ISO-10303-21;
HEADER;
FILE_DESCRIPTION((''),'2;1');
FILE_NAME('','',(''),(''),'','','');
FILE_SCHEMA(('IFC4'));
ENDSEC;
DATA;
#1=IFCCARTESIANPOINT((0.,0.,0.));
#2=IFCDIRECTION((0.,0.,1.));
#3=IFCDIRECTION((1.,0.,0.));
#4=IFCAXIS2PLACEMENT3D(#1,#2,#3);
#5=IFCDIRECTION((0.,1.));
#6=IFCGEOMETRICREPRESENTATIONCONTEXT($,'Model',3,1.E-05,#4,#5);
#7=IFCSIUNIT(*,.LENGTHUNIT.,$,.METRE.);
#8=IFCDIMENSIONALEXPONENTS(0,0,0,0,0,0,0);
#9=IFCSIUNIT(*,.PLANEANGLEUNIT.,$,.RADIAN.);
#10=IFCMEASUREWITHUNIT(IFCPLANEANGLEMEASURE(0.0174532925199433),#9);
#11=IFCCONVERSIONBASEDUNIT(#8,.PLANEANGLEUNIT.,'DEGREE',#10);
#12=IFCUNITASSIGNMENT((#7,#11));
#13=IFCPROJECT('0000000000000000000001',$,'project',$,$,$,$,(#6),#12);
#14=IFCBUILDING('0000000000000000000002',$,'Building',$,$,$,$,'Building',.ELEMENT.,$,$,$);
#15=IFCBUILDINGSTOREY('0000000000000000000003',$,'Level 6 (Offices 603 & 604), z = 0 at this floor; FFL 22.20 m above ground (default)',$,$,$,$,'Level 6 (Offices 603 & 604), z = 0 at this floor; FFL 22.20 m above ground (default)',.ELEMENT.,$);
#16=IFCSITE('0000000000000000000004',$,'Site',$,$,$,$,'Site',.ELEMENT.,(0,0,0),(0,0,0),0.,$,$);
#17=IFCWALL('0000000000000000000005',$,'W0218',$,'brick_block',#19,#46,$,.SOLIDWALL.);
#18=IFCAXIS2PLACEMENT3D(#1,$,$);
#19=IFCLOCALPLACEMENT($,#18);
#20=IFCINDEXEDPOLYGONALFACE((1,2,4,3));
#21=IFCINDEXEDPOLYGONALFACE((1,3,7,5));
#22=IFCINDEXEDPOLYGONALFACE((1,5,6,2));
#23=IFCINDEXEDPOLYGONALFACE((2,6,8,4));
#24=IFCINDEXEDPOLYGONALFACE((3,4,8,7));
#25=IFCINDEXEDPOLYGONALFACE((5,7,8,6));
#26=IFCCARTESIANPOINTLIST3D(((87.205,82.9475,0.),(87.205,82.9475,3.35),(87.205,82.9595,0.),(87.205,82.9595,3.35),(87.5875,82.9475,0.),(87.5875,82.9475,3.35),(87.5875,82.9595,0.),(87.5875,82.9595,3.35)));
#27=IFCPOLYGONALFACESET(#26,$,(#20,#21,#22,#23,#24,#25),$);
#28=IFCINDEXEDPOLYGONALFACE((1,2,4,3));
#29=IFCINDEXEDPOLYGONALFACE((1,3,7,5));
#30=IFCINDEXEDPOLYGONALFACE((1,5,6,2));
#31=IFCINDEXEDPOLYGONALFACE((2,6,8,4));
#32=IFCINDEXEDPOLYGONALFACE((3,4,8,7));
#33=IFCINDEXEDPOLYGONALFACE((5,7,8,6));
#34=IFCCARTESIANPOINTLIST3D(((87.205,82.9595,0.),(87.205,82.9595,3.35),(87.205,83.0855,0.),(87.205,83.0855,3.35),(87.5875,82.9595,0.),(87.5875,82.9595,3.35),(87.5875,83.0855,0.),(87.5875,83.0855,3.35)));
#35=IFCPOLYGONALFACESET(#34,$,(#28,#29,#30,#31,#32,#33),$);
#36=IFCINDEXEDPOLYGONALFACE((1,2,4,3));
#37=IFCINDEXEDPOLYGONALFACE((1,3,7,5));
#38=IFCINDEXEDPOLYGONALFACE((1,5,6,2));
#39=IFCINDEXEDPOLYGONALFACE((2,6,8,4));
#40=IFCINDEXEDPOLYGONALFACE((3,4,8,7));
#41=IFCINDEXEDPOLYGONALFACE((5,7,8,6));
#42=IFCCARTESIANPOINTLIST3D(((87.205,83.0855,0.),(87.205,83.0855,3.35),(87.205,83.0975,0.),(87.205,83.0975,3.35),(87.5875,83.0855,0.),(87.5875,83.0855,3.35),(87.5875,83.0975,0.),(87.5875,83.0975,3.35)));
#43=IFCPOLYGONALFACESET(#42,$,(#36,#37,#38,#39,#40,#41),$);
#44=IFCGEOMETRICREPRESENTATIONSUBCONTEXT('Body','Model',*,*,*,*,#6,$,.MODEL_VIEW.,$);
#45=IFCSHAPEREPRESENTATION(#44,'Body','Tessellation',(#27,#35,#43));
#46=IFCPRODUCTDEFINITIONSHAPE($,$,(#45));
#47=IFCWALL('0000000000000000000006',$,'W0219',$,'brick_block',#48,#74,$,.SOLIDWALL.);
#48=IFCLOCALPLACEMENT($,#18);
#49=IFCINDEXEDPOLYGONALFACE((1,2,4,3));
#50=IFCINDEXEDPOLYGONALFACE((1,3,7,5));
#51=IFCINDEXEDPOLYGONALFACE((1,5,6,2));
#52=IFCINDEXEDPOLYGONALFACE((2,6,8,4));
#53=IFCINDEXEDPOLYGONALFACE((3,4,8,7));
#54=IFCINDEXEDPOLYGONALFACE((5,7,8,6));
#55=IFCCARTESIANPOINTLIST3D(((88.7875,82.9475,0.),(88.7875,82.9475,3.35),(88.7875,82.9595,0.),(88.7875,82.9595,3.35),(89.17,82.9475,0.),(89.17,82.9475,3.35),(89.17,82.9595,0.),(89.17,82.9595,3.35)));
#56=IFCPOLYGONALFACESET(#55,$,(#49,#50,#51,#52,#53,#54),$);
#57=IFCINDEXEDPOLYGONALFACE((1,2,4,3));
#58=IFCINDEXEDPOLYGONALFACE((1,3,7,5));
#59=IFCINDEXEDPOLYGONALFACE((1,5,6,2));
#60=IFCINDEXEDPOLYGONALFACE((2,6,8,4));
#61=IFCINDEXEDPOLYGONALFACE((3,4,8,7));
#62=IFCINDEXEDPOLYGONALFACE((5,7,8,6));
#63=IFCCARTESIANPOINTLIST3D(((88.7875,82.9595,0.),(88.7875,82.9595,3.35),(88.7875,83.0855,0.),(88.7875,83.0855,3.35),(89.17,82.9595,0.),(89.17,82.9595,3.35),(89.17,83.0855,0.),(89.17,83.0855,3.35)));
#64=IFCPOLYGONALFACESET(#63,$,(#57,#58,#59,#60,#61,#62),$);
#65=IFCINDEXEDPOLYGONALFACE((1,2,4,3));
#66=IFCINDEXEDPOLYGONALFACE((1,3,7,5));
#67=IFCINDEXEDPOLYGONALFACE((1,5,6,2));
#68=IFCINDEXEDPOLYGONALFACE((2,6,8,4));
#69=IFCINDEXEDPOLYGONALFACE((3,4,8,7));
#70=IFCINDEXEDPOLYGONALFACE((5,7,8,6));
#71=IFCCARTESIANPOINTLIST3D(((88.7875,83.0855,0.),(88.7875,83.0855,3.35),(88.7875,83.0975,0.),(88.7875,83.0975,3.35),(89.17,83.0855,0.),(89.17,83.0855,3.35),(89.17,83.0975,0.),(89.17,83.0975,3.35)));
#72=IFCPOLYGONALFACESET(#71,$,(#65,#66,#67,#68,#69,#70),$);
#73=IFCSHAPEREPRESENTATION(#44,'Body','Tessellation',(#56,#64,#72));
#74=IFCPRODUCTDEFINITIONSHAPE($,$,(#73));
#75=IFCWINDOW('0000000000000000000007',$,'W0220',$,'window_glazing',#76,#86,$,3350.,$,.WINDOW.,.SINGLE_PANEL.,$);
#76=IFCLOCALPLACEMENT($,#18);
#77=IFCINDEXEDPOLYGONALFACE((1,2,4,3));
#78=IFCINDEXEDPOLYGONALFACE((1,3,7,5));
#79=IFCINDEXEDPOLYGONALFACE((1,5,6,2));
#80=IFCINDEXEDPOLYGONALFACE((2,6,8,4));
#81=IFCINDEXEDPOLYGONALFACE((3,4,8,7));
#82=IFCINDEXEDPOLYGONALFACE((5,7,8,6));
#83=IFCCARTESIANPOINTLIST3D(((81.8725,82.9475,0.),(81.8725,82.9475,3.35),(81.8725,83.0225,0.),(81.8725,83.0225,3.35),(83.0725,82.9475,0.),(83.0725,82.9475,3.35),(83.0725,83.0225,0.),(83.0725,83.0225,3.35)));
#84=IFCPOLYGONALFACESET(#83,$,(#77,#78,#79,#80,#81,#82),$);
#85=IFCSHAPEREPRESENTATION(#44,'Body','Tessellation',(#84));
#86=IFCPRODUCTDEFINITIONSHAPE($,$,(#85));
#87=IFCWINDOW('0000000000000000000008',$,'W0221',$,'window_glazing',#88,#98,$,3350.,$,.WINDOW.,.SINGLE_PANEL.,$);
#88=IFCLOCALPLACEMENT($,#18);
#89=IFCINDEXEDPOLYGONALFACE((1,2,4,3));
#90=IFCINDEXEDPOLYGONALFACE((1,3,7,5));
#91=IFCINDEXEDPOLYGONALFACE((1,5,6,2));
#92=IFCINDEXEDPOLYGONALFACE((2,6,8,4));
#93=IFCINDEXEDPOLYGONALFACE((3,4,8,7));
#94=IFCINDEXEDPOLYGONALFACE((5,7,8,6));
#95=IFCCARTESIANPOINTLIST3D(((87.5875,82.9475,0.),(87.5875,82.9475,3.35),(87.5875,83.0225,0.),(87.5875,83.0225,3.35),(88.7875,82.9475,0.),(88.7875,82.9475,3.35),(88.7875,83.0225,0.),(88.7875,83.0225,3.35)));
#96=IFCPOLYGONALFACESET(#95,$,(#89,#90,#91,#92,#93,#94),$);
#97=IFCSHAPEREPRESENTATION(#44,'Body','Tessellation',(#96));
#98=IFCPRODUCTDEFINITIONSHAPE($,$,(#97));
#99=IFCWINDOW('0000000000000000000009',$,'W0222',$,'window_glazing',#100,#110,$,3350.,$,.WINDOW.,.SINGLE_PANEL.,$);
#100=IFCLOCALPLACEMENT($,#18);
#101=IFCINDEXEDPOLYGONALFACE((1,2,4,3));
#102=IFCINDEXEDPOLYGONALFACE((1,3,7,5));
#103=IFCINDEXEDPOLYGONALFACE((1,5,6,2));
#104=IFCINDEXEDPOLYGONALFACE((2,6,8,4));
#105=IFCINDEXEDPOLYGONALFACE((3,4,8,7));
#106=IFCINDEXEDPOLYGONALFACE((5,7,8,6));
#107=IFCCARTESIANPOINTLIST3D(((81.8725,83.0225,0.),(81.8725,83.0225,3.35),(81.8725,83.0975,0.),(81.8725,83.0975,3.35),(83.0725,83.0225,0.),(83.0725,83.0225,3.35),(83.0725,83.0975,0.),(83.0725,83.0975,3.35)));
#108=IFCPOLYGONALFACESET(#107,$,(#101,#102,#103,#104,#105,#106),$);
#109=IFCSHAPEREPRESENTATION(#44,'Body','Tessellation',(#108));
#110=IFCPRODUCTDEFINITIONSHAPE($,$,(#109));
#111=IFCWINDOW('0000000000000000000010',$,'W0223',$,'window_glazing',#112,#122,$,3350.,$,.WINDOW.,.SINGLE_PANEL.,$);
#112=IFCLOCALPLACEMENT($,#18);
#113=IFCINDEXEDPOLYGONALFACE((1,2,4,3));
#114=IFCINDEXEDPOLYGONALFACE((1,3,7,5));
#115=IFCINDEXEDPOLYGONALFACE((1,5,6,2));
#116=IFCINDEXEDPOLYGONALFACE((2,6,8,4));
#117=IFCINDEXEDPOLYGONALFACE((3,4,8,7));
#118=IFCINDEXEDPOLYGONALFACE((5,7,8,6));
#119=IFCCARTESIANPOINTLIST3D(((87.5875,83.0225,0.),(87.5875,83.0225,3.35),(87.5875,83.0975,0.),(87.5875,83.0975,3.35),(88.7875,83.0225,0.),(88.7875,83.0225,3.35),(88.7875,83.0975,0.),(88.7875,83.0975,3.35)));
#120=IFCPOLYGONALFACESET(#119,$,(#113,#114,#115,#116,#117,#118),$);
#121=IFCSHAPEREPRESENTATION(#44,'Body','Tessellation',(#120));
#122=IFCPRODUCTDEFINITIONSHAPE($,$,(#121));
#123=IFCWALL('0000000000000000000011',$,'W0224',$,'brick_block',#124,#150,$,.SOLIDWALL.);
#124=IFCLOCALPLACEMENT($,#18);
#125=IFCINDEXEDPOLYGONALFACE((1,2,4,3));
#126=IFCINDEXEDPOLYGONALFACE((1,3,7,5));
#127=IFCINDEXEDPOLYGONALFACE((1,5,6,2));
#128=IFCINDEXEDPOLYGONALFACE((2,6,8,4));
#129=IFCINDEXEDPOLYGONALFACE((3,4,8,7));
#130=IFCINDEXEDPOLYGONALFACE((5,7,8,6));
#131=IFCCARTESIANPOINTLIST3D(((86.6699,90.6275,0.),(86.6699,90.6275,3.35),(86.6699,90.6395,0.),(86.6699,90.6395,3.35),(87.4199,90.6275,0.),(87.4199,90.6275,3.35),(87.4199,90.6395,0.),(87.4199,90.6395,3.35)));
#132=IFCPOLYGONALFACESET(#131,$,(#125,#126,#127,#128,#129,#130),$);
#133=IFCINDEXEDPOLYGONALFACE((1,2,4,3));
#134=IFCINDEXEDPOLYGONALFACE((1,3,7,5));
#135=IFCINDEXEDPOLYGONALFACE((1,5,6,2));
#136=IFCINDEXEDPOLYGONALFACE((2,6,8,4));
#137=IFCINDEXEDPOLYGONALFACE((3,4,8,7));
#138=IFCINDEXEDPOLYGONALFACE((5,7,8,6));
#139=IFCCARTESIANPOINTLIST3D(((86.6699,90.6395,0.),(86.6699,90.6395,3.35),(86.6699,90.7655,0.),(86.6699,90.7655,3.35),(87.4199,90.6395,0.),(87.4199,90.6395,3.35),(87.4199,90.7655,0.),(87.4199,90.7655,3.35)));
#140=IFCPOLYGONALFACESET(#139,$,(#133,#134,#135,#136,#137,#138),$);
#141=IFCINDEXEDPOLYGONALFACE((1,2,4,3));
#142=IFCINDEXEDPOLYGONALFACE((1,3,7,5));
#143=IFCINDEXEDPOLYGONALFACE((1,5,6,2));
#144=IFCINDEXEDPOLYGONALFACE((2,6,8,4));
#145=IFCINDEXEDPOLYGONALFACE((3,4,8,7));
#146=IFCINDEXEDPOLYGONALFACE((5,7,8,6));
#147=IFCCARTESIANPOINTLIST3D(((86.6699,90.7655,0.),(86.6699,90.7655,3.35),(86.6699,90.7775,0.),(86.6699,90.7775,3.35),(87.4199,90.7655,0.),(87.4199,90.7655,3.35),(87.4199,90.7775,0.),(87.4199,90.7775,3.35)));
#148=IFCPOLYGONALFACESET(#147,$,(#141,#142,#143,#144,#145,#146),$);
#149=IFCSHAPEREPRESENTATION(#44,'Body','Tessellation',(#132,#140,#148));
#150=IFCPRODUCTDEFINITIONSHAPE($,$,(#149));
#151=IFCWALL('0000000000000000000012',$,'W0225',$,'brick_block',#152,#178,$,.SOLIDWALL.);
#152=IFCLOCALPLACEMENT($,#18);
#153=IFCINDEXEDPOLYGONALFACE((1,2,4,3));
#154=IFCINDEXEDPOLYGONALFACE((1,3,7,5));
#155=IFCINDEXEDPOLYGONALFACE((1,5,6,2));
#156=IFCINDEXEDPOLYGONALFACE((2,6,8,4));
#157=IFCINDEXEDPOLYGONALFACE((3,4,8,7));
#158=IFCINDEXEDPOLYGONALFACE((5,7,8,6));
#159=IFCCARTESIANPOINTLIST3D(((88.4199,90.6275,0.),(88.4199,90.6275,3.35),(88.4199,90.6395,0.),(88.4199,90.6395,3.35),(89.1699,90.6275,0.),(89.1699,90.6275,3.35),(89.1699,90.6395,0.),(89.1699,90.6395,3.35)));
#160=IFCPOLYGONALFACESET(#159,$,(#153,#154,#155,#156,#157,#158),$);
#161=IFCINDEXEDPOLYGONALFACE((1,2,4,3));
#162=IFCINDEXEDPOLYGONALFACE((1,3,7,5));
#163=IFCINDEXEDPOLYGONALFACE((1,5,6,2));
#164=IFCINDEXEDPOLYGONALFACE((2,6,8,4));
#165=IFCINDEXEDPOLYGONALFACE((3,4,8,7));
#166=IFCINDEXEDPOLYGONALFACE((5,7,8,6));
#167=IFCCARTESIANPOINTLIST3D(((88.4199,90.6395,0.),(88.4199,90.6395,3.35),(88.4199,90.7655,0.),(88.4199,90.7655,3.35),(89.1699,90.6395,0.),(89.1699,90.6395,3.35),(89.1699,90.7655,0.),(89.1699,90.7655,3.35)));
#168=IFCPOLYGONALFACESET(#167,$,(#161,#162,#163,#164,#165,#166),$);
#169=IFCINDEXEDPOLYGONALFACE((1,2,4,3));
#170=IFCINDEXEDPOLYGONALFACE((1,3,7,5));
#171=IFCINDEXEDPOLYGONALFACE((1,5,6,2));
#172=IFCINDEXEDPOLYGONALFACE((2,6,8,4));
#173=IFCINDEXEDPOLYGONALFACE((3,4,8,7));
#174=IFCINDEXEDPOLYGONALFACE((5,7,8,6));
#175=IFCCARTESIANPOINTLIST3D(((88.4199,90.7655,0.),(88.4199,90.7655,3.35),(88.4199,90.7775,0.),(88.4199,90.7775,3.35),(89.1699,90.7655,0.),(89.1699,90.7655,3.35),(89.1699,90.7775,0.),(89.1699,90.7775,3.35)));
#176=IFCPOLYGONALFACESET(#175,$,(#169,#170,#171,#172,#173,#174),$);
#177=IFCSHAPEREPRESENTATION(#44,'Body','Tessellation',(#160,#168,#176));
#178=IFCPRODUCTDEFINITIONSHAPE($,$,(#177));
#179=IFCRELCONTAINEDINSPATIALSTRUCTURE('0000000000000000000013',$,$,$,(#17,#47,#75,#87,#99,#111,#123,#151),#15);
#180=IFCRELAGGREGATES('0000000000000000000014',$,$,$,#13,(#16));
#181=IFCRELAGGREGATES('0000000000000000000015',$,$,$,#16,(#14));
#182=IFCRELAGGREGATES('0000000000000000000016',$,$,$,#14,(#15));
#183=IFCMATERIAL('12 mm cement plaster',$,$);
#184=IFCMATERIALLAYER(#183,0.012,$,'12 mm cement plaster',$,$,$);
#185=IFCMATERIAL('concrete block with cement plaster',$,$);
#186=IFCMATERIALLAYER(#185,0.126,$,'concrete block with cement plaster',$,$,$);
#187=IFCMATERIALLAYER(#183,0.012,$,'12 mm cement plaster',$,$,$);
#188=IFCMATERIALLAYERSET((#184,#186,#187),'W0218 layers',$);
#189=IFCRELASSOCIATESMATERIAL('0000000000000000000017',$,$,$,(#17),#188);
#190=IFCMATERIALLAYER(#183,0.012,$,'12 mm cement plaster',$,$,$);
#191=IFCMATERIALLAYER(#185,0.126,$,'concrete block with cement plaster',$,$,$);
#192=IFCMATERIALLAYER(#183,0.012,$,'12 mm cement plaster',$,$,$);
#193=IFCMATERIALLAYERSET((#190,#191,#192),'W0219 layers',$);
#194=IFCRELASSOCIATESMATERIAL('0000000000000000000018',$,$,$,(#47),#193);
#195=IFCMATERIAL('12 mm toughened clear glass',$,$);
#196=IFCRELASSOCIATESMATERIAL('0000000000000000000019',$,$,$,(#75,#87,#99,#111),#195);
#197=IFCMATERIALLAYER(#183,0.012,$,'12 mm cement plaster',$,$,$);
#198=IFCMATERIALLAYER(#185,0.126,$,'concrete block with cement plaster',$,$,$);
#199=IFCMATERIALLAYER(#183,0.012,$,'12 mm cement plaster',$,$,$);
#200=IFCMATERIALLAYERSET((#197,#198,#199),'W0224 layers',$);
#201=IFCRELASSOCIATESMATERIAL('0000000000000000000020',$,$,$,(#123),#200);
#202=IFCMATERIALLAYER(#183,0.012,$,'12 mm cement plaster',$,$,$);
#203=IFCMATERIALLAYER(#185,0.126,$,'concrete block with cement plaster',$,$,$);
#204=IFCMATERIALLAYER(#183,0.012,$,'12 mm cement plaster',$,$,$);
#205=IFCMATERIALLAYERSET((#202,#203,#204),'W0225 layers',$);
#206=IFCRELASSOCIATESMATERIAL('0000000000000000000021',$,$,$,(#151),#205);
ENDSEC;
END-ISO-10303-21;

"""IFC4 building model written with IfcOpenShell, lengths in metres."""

from ifc_helpers import new_model, entity, si_unit, converted_unit, direction, frame, frame_2d, origin_with_axes, origin_2d_with_axis, place, context, subcontext, project, spatial, rectangle, extrude, material, layer, layer_set, layer_usage, element, save


model = new_model("IFC4")

# Units and contexts
model_context = context("Model", 3, precision=1e-05, world=origin_with_axes(), true_north=direction((0.0, 1.0)))
body_context = subcontext(model_context, "Body", "Model", "MODEL_VIEW")
ifc_project = project(units=[si_unit("LENGTHUNIT", "METRE"), converted_unit("PLANEANGLEUNIT", "DEGREE", entity("IfcPlaneAngleMeasure", 0.0174532925199433), si_unit("PLANEANGLEUNIT", "RADIAN"), dimensions=[0, 0, 0, 0, 0, 0, 0])], contexts=[model_context])

# Site, building, storey
site = spatial("IfcSite", under=ifc_project, Name="Site", LongName="Site", CompositionType="ELEMENT", RefLatitude=(0, 0, 0), RefLongitude=(0, 0, 0), RefElevation=0.0)
building = spatial("IfcBuilding", under=site, Name="Building", LongName="Building", CompositionType="ELEMENT")
storey = spatial("IfcBuildingStorey", under=building, Name="Level 6 (Offices 603 & 604), z = 0 at this floor; FFL 22.20 m above ground (default)", LongName="Level 6 (Offices 603 & 604), z = 0 at this floor; FFL 22.20 m above ground (default)", CompositionType="ELEMENT")

# Walls
ifc_material_1 = material(Name="12 mm cement plaster")
ifc_layer_1 = layer(ifc_material_1, 0.012, Name="12 mm cement plaster")
ifc_material_2 = material(Name="concrete block with cement plaster")
ifc_layer_2 = layer(ifc_material_2, 0.126, Name="concrete block with cement plaster")
ifc_layer_3 = layer(ifc_material_1, 0.012, Name="12 mm cement plaster")
ifc_layer_set_1 = layer_set([ifc_layer_1, ifc_layer_2, ifc_layer_3], Name="W0218 layers")
ifc_layer_usage_1 = layer_usage(ifc_layer_set_1, "AXIS2", "POSITIVE", -0.075)
placement = place(None, origin_with_axes())
element("IfcWall", 1, at=placement, inside=storey, material=ifc_layer_usage_1, Name="W0218", ObjectType="brick_block", PredefinedType="SOLIDWALL", context=body_context, shape_type="SweptSolid", body=[
    extrude(rectangle(XDim=0.3825, YDim=0.012, at=frame_2d((0.0, 0.0), x_axis=(1.0, 0.0))), frame((87.3962, 82.9535, 0.0), z_axis=(0.0, 0.0, 1.0), x_axis=(1.0, 0.0, 0.0)), (0.0, 0.0, 1.0), 3.35),
    extrude(rectangle(XDim=0.3825, YDim=0.126, at=frame_2d((0.0, 0.069), x_axis=(1.0, 0.0))), frame((87.3962, 82.9535, 0.0), z_axis=(0.0, 0.0, 1.0), x_axis=(1.0, 0.0, 0.0)), (0.0, 0.0, 1.0), 3.35),
    extrude(rectangle(XDim=0.3825, YDim=0.012, at=frame_2d((0.0, 0.138), x_axis=(1.0, 0.0))), frame((87.3962, 82.9535, 0.0), z_axis=(0.0, 0.0, 1.0), x_axis=(1.0, 0.0, 0.0)), (0.0, 0.0, 1.0), 3.35),
])
ifc_layer_4 = layer(ifc_material_1, 0.012, Name="12 mm cement plaster")
ifc_layer_5 = layer(ifc_material_2, 0.126, Name="concrete block with cement plaster")
ifc_layer_6 = layer(ifc_material_1, 0.012, Name="12 mm cement plaster")
ifc_layer_set_2 = layer_set([ifc_layer_4, ifc_layer_5, ifc_layer_6], Name="W0219 layers")
ifc_layer_usage_2 = layer_usage(ifc_layer_set_2, "AXIS2", "POSITIVE", -0.075)
element("IfcWall", 2, at=placement, inside=storey, material=ifc_layer_usage_2, Name="W0219", ObjectType="brick_block", PredefinedType="SOLIDWALL", context=body_context, shape_type="SweptSolid", body=[
    extrude(rectangle(XDim=0.3825, YDim=0.012, at=frame_2d((0.0, 0.0), x_axis=(1.0, 0.0))), frame((88.9788, 82.9535, 0.0), z_axis=(0.0, 0.0, 1.0), x_axis=(1.0, 0.0, 0.0)), (0.0, 0.0, 1.0), 3.35),
    extrude(rectangle(XDim=0.3825, YDim=0.126, at=frame_2d((0.0, 0.069), x_axis=(1.0, 0.0))), frame((88.9788, 82.9535, 0.0), z_axis=(0.0, 0.0, 1.0), x_axis=(1.0, 0.0, 0.0)), (0.0, 0.0, 1.0), 3.35),
    extrude(rectangle(XDim=0.3825, YDim=0.012, at=frame_2d((0.0, 0.138), x_axis=(1.0, 0.0))), frame((88.9788, 82.9535, 0.0), z_axis=(0.0, 0.0, 1.0), x_axis=(1.0, 0.0, 0.0)), (0.0, 0.0, 1.0), 3.35),
])

# Windows
ifc_material_3 = material(Name="12 mm toughened clear glass")
element("IfcWindow", 3, at=placement, inside=storey, material=ifc_material_3, Name="W0220", ObjectType="window_glazing", OverallHeight=3350.0, PartitioningType="SINGLE_PANEL", PredefinedType="WINDOW", context=body_context, shape_type="SweptSolid", body=[
    extrude(rectangle(XDim=1.2, YDim=0.075, at=frame_2d((0.0, 0.0), x_axis=(1.0, 0.0))), frame((82.4725, 82.985, 0.0), z_axis=(0.0, 0.0, 1.0), x_axis=(1.0, 0.0, 0.0)), (0.0, 0.0, 1.0), 3.35),
])
element("IfcWindow", 4, at=placement, inside=storey, material=ifc_material_3, Name="W0221", ObjectType="window_glazing", OverallHeight=3350.0, PartitioningType="SINGLE_PANEL", PredefinedType="WINDOW", context=body_context, shape_type="SweptSolid", body=[
    extrude(rectangle(XDim=1.2, YDim=0.075, at=frame_2d((0.0, 0.0), x_axis=(1.0, 0.0))), frame((88.1875, 82.985, 0.0), z_axis=(0.0, 0.0, 1.0), x_axis=(1.0, 0.0, 0.0)), (0.0, 0.0, 1.0), 3.35),
])
element("IfcWindow", 5, at=placement, inside=storey, material=ifc_material_3, Name="W0222", ObjectType="window_glazing", OverallHeight=3350.0, PartitioningType="SINGLE_PANEL", PredefinedType="WINDOW", context=body_context, shape_type="SweptSolid", body=[
    extrude(rectangle(XDim=1.2, YDim=0.075, at=frame_2d((0.0, 0.0), x_axis=(1.0, 0.0))), frame((82.4725, 83.06, 0.0), z_axis=(0.0, 0.0, 1.0), x_axis=(1.0, 0.0, 0.0)), (0.0, 0.0, 1.0), 3.35),
])
element("IfcWindow", 6, at=placement, inside=storey, material=ifc_material_3, Name="W0223", ObjectType="window_glazing", OverallHeight=3350.0, PartitioningType="SINGLE_PANEL", PredefinedType="WINDOW", context=body_context, shape_type="SweptSolid", body=[
    extrude(rectangle(XDim=1.2, YDim=0.075, at=frame_2d((0.0, 0.0), x_axis=(1.0, 0.0))), frame((88.1875, 83.06, 0.0), z_axis=(0.0, 0.0, 1.0), x_axis=(1.0, 0.0, 0.0)), (0.0, 0.0, 1.0), 3.35),
])

# Walls
ifc_layer_7 = layer(ifc_material_1, 0.012, Name="12 mm cement plaster")
ifc_layer_8 = layer(ifc_material_2, 0.126, Name="concrete block with cement plaster")
ifc_layer_9 = layer(ifc_material_1, 0.012, Name="12 mm cement plaster")
ifc_layer_set_3 = layer_set([ifc_layer_7, ifc_layer_8, ifc_layer_9], Name="W0224 layers")
ifc_layer_usage_3 = layer_usage(ifc_layer_set_3, "AXIS2", "POSITIVE", -0.075)
element("IfcWall", 7, at=placement, inside=storey, material=ifc_layer_usage_3, Name="W0224", ObjectType="brick_block", PredefinedType="SOLIDWALL", context=body_context, shape_type="SweptSolid", body=[
    extrude(rectangle(XDim=0.75, YDim=0.012, at=origin_2d_with_axis()), frame((87.0449, 90.6335, 0.0), z_axis=(0.0, 0.0, 1.0), x_axis=(1.0, 0.0, 0.0)), (0.0, 0.0, 1.0), 3.35),
    extrude(rectangle(XDim=0.75, YDim=0.126, at=frame_2d((0.0, 0.069), x_axis=(1.0, 0.0))), frame((87.0449, 90.6335, 0.0), z_axis=(0.0, 0.0, 1.0), x_axis=(1.0, 0.0, 0.0)), (0.0, 0.0, 1.0), 3.35),
    extrude(rectangle(XDim=0.75, YDim=0.012, at=frame_2d((0.0, 0.138), x_axis=(1.0, 0.0))), frame((87.0449, 90.6335, 0.0), z_axis=(0.0, 0.0, 1.0), x_axis=(1.0, 0.0, 0.0)), (0.0, 0.0, 1.0), 3.35),
])
ifc_layer_10 = layer(ifc_material_1, 0.012, Name="12 mm cement plaster")
ifc_layer_11 = layer(ifc_material_2, 0.126, Name="concrete block with cement plaster")
ifc_layer_12 = layer(ifc_material_1, 0.012, Name="12 mm cement plaster")
ifc_layer_set_4 = layer_set([ifc_layer_10, ifc_layer_11, ifc_layer_12], Name="W0225 layers")
ifc_layer_usage_4 = layer_usage(ifc_layer_set_4, "AXIS2", "POSITIVE", -0.075)
element("IfcWall", 8, at=placement, inside=storey, material=ifc_layer_usage_4, Name="W0225", ObjectType="brick_block", PredefinedType="SOLIDWALL", context=body_context, shape_type="SweptSolid", body=[
    extrude(rectangle(XDim=0.75, YDim=0.012, at=origin_2d_with_axis()), frame((88.7949, 90.6335, 0.0), z_axis=(0.0, 0.0, 1.0), x_axis=(1.0, 0.0, 0.0)), (0.0, 0.0, 1.0), 3.35),
    extrude(rectangle(XDim=0.75, YDim=0.126, at=frame_2d((0.0, 0.069), x_axis=(1.0, 0.0))), frame((88.7949, 90.6335, 0.0), z_axis=(0.0, 0.0, 1.0), x_axis=(1.0, 0.0, 0.0)), (0.0, 0.0, 1.0), 3.35),
    extrude(rectangle(XDim=0.75, YDim=0.012, at=frame_2d((0.0, 0.138), x_axis=(1.0, 0.0))), frame((88.7949, 90.6335, 0.0), z_axis=(0.0, 0.0, 1.0), x_axis=(1.0, 0.0, 0.0)), (0.0, 0.0, 1.0), 3.35),
])

save(model, "model.ifc")
